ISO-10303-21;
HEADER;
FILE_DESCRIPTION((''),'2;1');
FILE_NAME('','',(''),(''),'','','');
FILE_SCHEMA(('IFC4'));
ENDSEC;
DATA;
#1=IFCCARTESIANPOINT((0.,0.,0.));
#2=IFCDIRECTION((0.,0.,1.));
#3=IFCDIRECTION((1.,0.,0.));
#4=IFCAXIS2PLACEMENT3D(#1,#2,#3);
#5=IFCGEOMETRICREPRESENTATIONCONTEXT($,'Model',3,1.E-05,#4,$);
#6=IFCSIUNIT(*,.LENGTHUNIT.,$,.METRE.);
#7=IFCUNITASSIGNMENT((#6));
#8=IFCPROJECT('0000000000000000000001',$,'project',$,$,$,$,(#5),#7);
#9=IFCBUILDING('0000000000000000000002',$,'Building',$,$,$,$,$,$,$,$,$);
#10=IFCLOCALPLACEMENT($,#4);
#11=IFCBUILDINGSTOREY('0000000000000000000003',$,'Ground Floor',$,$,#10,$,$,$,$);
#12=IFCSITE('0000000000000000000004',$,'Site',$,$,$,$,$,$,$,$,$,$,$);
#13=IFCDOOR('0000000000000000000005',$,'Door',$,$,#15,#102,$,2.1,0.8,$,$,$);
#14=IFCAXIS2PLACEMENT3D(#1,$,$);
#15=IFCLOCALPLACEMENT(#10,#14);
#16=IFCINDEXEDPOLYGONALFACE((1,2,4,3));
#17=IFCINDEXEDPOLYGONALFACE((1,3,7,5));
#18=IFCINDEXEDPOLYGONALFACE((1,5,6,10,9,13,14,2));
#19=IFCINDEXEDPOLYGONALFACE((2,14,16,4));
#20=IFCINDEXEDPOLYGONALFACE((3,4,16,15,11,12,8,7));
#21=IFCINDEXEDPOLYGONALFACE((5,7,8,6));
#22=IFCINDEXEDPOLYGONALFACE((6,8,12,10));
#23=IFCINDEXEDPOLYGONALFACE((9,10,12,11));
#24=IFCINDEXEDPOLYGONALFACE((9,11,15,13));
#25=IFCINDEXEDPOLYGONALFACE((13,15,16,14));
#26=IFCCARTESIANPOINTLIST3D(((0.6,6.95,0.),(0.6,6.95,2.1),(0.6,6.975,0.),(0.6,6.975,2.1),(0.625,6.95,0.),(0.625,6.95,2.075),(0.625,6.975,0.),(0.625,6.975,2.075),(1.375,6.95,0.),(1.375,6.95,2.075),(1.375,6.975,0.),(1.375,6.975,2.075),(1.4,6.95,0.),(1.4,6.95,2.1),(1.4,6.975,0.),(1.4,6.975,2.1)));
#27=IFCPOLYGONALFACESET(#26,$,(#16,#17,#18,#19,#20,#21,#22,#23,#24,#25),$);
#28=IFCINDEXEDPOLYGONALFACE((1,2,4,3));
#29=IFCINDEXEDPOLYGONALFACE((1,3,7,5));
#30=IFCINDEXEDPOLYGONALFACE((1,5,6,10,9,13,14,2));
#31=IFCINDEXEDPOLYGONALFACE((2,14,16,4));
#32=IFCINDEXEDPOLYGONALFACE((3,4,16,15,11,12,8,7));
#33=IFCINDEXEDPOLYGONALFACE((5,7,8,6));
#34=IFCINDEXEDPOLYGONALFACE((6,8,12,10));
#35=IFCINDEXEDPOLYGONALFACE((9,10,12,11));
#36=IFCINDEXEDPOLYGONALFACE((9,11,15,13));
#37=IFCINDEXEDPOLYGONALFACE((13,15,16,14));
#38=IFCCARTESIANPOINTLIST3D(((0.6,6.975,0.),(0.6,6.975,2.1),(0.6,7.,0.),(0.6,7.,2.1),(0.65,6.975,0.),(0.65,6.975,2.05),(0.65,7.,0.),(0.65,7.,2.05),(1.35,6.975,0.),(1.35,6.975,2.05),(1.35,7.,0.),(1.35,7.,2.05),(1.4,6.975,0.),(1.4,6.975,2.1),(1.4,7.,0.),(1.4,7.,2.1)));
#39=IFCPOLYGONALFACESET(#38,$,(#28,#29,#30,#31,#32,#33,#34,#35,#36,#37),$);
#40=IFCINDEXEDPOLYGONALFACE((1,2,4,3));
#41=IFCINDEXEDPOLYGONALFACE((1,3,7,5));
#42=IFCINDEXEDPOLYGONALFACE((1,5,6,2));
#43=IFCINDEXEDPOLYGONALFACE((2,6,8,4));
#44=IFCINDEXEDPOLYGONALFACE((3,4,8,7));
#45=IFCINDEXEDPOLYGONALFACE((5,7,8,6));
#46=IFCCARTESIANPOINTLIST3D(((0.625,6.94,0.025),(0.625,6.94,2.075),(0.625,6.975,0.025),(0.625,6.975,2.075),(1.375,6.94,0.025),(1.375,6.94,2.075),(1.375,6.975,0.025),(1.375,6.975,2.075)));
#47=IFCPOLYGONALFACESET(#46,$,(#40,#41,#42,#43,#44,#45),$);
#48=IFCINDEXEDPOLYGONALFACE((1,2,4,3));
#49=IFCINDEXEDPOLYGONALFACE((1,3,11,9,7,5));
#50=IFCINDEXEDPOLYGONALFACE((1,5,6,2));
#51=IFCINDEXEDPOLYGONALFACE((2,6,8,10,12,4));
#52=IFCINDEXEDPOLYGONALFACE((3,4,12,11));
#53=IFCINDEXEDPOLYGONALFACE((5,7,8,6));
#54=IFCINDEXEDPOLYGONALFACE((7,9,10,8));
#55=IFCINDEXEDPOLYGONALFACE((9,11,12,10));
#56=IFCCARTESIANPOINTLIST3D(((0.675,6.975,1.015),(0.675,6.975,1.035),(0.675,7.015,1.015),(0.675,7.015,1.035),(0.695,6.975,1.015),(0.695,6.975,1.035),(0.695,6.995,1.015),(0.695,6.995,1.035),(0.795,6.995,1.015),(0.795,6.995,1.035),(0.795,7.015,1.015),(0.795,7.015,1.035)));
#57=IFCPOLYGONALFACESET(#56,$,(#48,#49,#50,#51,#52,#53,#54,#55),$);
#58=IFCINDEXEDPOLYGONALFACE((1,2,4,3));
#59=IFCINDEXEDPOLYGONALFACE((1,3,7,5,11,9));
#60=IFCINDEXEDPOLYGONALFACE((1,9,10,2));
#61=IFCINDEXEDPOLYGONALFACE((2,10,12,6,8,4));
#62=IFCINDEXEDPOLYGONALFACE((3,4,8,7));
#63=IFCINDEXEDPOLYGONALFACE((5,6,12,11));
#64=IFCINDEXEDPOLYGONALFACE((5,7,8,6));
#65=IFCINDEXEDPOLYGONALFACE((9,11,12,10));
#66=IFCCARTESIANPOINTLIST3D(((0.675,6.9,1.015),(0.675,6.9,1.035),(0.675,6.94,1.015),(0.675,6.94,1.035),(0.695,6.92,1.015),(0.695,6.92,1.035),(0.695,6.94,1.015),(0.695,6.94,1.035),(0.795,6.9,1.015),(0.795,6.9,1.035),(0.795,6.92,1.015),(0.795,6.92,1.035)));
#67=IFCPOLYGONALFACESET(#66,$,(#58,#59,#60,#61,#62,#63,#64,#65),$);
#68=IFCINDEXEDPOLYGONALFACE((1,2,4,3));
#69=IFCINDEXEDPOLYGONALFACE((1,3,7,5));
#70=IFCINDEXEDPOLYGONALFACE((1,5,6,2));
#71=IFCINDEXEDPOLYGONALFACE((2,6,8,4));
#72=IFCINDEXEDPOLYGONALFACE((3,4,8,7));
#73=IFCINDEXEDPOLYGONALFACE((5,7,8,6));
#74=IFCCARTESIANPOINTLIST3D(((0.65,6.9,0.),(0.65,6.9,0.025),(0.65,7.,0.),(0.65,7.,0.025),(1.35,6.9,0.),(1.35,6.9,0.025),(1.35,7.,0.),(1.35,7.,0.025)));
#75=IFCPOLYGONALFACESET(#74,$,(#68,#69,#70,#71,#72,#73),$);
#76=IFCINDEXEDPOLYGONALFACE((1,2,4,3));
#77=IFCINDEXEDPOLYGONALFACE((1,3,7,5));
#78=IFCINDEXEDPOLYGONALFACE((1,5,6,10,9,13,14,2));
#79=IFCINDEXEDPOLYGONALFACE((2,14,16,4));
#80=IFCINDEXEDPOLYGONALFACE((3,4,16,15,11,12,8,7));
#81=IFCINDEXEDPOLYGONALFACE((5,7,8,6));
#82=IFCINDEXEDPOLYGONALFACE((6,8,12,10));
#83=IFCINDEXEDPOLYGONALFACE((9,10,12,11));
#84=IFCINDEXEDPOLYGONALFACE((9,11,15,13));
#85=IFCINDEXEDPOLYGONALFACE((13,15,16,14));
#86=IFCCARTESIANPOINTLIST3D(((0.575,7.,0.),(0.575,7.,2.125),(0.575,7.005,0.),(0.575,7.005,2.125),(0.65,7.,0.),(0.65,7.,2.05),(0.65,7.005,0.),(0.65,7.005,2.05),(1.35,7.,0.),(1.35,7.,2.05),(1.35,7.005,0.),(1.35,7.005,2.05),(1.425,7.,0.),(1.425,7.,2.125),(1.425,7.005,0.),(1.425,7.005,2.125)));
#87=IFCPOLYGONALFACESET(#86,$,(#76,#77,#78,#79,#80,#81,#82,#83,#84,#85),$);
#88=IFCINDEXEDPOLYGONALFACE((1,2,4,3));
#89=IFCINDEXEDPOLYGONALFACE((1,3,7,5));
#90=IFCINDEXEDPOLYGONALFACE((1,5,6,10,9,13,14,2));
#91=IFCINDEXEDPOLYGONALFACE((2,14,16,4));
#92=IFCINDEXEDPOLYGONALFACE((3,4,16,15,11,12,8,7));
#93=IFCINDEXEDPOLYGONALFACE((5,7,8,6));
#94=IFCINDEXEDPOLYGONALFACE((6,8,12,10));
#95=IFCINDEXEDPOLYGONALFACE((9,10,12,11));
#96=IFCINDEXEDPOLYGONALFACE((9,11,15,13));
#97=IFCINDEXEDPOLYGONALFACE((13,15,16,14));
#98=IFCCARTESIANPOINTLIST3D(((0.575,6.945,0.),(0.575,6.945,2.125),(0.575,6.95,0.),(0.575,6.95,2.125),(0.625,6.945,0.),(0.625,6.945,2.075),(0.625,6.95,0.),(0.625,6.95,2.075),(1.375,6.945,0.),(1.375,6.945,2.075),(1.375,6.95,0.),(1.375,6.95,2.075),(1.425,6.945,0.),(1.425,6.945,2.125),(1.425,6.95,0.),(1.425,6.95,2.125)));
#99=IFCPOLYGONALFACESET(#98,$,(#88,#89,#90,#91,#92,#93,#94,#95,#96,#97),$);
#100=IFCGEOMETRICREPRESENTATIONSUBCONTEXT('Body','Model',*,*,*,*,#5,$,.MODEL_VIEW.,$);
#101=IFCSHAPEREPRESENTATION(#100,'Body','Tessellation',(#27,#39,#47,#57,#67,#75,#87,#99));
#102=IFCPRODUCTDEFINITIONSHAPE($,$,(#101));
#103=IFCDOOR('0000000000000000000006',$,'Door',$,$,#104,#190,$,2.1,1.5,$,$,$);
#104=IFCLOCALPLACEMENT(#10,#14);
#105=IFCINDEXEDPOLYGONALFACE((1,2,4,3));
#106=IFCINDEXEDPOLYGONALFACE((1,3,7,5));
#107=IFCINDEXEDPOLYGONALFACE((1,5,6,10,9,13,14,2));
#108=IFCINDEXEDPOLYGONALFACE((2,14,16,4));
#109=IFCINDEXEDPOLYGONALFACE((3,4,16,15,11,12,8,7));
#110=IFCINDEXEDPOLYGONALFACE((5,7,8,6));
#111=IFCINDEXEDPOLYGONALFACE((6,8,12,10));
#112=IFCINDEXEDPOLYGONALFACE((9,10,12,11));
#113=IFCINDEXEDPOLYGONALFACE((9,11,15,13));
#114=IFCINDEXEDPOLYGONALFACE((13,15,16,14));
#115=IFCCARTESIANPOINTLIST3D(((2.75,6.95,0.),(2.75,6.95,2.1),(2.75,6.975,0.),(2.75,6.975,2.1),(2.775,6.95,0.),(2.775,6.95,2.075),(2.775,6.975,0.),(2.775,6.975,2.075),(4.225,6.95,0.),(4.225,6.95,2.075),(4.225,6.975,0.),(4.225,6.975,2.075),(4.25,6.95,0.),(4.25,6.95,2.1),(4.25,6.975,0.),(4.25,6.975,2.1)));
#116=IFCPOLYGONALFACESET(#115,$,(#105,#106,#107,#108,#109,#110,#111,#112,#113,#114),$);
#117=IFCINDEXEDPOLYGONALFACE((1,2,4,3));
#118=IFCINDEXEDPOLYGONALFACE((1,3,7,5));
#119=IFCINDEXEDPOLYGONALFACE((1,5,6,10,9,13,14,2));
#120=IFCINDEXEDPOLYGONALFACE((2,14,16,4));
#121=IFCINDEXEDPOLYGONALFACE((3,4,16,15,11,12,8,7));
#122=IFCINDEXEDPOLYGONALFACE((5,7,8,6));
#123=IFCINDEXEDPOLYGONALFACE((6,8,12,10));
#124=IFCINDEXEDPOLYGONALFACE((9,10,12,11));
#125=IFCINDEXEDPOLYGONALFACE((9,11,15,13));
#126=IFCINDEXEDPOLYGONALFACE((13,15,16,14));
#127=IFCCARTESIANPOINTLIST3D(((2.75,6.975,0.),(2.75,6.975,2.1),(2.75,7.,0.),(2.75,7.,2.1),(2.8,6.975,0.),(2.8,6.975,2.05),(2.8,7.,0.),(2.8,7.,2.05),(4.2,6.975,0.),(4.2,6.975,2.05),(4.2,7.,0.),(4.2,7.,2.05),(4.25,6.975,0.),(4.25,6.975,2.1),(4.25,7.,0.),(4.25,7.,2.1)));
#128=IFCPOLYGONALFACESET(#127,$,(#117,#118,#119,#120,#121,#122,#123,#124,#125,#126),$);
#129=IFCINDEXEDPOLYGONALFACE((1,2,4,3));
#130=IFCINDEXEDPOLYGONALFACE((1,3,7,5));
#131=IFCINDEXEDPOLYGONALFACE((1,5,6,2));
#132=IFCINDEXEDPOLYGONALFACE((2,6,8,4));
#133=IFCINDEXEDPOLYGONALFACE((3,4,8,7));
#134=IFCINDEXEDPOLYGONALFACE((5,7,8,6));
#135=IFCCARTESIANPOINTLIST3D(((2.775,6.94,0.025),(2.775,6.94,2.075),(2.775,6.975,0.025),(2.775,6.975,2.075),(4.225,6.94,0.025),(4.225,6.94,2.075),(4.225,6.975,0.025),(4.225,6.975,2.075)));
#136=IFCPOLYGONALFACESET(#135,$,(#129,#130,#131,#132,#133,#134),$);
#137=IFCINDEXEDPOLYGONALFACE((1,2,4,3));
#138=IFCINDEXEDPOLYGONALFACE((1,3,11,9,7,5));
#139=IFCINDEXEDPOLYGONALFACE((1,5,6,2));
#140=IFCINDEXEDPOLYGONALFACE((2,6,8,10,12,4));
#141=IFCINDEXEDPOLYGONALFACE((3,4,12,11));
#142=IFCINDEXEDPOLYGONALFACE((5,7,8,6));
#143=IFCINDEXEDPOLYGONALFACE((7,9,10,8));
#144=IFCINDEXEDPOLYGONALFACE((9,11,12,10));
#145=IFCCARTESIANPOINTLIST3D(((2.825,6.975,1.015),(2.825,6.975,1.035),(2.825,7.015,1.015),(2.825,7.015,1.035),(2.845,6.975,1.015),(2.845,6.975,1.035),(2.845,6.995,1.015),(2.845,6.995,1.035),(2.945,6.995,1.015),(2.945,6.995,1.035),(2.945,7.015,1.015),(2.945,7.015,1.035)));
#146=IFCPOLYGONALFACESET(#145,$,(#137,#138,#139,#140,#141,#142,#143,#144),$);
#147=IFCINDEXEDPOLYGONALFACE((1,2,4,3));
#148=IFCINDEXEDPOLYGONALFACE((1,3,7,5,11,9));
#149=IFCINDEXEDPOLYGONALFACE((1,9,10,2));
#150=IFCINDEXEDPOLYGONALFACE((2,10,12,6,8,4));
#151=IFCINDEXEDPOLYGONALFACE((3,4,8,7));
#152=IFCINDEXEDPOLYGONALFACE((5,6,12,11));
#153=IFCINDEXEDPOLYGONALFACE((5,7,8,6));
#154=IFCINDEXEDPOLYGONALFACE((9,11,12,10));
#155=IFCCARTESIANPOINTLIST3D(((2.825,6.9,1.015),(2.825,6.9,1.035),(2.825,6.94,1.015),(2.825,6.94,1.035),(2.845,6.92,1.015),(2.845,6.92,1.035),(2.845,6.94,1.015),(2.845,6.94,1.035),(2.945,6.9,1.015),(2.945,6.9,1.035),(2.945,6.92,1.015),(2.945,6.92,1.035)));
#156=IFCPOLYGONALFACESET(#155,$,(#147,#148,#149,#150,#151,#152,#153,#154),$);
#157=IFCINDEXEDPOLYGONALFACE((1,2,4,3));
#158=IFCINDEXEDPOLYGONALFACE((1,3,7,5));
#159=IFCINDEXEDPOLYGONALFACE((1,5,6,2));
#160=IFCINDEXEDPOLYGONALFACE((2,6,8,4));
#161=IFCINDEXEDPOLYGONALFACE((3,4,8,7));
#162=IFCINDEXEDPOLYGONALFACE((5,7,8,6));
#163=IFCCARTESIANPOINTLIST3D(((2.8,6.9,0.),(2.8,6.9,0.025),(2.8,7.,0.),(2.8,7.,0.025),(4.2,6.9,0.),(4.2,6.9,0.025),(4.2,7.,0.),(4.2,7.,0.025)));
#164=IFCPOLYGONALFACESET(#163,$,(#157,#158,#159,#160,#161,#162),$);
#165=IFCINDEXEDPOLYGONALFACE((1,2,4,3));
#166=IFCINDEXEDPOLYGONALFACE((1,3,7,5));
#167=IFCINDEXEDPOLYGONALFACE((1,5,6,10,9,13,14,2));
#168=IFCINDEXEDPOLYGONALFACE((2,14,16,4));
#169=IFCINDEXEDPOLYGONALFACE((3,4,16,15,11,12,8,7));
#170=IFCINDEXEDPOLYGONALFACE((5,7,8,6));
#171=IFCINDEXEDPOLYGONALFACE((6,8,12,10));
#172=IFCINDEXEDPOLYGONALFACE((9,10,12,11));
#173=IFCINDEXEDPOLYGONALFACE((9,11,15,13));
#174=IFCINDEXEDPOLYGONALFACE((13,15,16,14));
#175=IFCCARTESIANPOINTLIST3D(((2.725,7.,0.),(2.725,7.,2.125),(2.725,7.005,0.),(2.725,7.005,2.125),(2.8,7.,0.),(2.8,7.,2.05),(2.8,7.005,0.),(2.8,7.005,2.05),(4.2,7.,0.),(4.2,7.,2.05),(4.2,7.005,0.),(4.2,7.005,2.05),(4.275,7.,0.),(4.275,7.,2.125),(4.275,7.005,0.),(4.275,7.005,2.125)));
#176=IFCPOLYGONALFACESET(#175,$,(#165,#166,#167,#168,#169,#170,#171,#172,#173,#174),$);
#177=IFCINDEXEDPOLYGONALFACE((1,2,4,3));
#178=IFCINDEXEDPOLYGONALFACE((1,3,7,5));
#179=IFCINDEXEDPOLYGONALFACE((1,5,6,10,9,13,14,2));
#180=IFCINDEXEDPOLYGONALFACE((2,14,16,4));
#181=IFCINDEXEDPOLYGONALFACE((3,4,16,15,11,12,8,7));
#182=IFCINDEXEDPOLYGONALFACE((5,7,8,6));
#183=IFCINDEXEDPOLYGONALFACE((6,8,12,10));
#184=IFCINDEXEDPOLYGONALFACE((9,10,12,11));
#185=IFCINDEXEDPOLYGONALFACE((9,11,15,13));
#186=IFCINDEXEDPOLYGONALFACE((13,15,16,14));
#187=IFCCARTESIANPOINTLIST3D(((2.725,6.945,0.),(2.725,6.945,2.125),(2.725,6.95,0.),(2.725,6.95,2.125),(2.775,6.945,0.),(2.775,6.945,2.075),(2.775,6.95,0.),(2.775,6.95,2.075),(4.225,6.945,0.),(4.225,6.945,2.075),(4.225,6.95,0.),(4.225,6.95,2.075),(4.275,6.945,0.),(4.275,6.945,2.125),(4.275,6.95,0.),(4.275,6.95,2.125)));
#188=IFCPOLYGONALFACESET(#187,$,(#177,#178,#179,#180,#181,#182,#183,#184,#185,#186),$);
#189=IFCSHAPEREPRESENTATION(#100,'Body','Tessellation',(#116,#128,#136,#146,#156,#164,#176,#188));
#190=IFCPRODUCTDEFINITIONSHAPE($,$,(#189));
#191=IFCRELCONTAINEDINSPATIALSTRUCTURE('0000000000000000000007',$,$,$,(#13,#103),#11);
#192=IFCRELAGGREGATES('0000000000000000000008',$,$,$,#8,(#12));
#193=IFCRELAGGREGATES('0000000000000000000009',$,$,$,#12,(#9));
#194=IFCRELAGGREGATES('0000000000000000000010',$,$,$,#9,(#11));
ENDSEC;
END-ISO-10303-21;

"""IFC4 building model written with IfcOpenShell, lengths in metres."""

from ifc_helpers import new_model, si_unit, frame, origin_with_axes, place, context, subcontext, project, spatial, line, indexed_curve, outline, extrude, element, save


model = new_model("IFC4")

# Units and contexts
model_context = context("Model", 3, precision=1e-05, world=origin_with_axes())
body_context = subcontext(model_context, "Body", "Model", "MODEL_VIEW")
ifc_project = project(units=[si_unit("LENGTHUNIT", "METRE")], contexts=[model_context])

# Site, building, storey
site = spatial("IfcSite", under=ifc_project, Name="Site")
building = spatial("IfcBuilding", under=site, Name="Building")
storey_placement = place(None, origin_with_axes())
storey = spatial("IfcBuildingStorey", under=building, at=storey_placement, Name="Ground Floor")

# Doors
door_1_placement = place(storey_placement, frame((1.4, 7.0, 0.0), z_axis=(0.0, 0.0, 1.0), x_axis=(-1.0, 0.0, 0.0)))
element("IfcDoor", 1, at=door_1_placement, inside=storey, Name="Door", OverallHeight=2.1, OverallWidth=0.8, context=body_context, shape_type="SweptSolid", body=[
    extrude(outline(indexed_curve([(0.0, 0.0), (0.0, 2.1), (0.8, 2.1), (0.8, 0.0), (0.775, 0.0), (0.775, 2.075), (0.025, 2.075), (0.025, 0.0)], segments=[line(1, 2, 3, 4, 5, 6, 7, 8, 1)])), frame((0.0, 0.025, 0.0), z_axis=(0.0, -1.0, 0.0), x_axis=(1.0, 0.0, 0.0)), (0.0, 0.0, -1.0), 0.025),
    extrude(outline(indexed_curve([(0.0, 0.0), (0.0, 2.1), (0.8, 2.1), (0.8, 0.0), (0.75, 0.0), (0.75, 2.05), (0.05, 2.05), (0.05, 0.0)], segments=[line(1, 2, 3, 4, 5, 6, 7, 8, 1)])), frame((0.0, 0.0, 0.0), z_axis=(0.0, -1.0, 0.0), x_axis=(1.0, 0.0, 0.0)), (0.0, 0.0, -1.0), 0.025),
    extrude(outline(indexed_curve([(0.0, 0.0), (0.75, 0.0), (0.75, 0.035), (0.0, 0.035)], segments=[line(1, 2, 3, 4, 1)])), frame((0.025, 0.025, 0.025), z_axis=(0.0, 0.0, 1.0), x_axis=(1.0, 0.0, 0.0)), (0.0, 0.0, 1.0), 2.05),
    extrude(outline(indexed_curve([(0.0, 0.0), (0.0, -0.04), (-0.12, -0.04), (-0.12, -0.02), (-0.02, -0.02), (-0.02, 0.0)], segments=[line(1, 2, 3, 4, 5, 6, 1)])), frame((0.725, 0.025, 1.015), z_axis=(0.0, 0.0, 1.0), x_axis=(1.0, 0.0, 0.0)), (0.0, 0.0, 1.0), 0.02),
    extrude(outline(indexed_curve([(0.0, 0.0), (0.0, 0.04), (-0.12, 0.04), (-0.12, 0.02), (-0.02, 0.02), (-0.02, 0.0)], segments=[line(1, 2, 3, 4, 5, 6, 1)])), frame((0.725, 0.06, 1.015), z_axis=(0.0, 0.0, 1.0), x_axis=(1.0, 0.0, 0.0)), (0.0, 0.0, 1.0), 0.02),
    extrude(outline(indexed_curve([(0.0, 0.0), (0.7, 0.0), (0.7, 0.1), (0.0, 0.1)], segments=[line(1, 2, 3, 4, 1)])), frame((0.05, 0.0, 0.0), z_axis=(0.0, 0.0, 1.0), x_axis=(1.0, 0.0, 0.0)), (0.0, 0.0, 1.0), 0.025),
    extrude(outline(indexed_curve([(0.0, 0.0), (0.0, 2.125), (0.85, 2.125), (0.85, 0.0), (0.775, 0.0), (0.775, 2.05), (0.075, 2.05), (0.075, 0.0)], segments=[line(1, 2, 3, 4, 5, 6, 7, 8, 1)])), frame((-0.025, -0.005, 0.0), z_axis=(0.0, -1.0, 0.0), x_axis=(1.0, 0.0, 0.0)), (0.0, 0.0, -1.0), 0.005),
    extrude(outline(indexed_curve([(0.0, 0.0), (0.0, 2.125), (0.85, 2.125), (0.85, 0.0), (0.8, 0.0), (0.8, 2.075), (0.05, 2.075), (0.05, 0.0)], segments=[line(1, 2, 3, 4, 5, 6, 7, 8, 1)])), frame((-0.025, 0.05, 0.0), z_axis=(0.0, -1.0, 0.0), x_axis=(1.0, 0.0, 0.0)), (0.0, 0.0, -1.0), 0.005),
])
door_2_placement = place(storey_placement, frame((4.25, 7.0, 0.0), z_axis=(0.0, 0.0, 1.0), x_axis=(-1.0, 0.0, 0.0)))
element("IfcDoor", 2, at=door_2_placement, inside=storey, Name="Door", OverallHeight=2.1, OverallWidth=1.5, context=body_context, shape_type="SweptSolid", body=[
    extrude(outline(indexed_curve([(0.0, 0.0), (0.0, 2.1), (1.5, 2.1), (1.5, 0.0), (1.475, 0.0), (1.475, 2.075), (0.025, 2.075), (0.025, 0.0)], segments=[line(1, 2, 3, 4, 5, 6, 7, 8, 1)])), frame((0.0, 0.025, 0.0), z_axis=(0.0, -1.0, 0.0), x_axis=(1.0, 0.0, 0.0)), (0.0, 0.0, -1.0), 0.025),
    extrude(outline(indexed_curve([(0.0, 0.0), (0.0, 2.1), (1.5, 2.1), (1.5, 0.0), (1.45, 0.0), (1.45, 2.05), (0.05, 2.05), (0.05, 0.0)], segments=[line(1, 2, 3, 4, 5, 6, 7, 8, 1)])), frame((0.0, 0.0, 0.0), z_axis=(0.0, -1.0, 0.0), x_axis=(1.0, 0.0, 0.0)), (0.0, 0.0, -1.0), 0.025),
    extrude(outline(indexed_curve([(0.0, 0.0), (1.45, 0.0), (1.45, 0.035), (0.0, 0.035)], segments=[line(1, 2, 3, 4, 1)])), frame((0.025, 0.025, 0.025), z_axis=(0.0, 0.0, 1.0), x_axis=(1.0, 0.0, 0.0)), (0.0, 0.0, 1.0), 2.05),
    extrude(outline(indexed_curve([(0.0, 0.0), (0.0, -0.04), (-0.12, -0.04), (-0.12, -0.02), (-0.02, -0.02), (-0.02, 0.0)], segments=[line(1, 2, 3, 4, 5, 6, 1)])), frame((1.425, 0.025, 1.015), z_axis=(0.0, 0.0, 1.0), x_axis=(1.0, 0.0, 0.0)), (0.0, 0.0, 1.0), 0.02),
    extrude(outline(indexed_curve([(0.0, 0.0), (0.0, 0.04), (-0.12, 0.04), (-0.12, 0.02), (-0.02, 0.02), (-0.02, 0.0)], segments=[line(1, 2, 3, 4, 5, 6, 1)])), frame((1.425, 0.06, 1.015), z_axis=(0.0, 0.0, 1.0), x_axis=(1.0, 0.0, 0.0)), (0.0, 0.0, 1.0), 0.02),
    extrude(outline(indexed_curve([(0.0, 0.0), (1.4, 0.0), (1.4, 0.1), (0.0, 0.1)], segments=[line(1, 2, 3, 4, 1)])), frame((0.05, 0.0, 0.0), z_axis=(0.0, 0.0, 1.0), x_axis=(1.0, 0.0, 0.0)), (0.0, 0.0, 1.0), 0.025),
    extrude(outline(indexed_curve([(0.0, 0.0), (0.0, 2.125), (1.55, 2.125), (1.55, 0.0), (1.475, 0.0), (1.475, 2.05), (0.075, 2.05), (0.075, 0.0)], segments=[line(1, 2, 3, 4, 5, 6, 7, 8, 1)])), frame((-0.025, -0.005, 0.0), z_axis=(0.0, -1.0, 0.0), x_axis=(1.0, 0.0, 0.0)), (0.0, 0.0, -1.0), 0.005),
    extrude(outline(indexed_curve([(0.0, 0.0), (0.0, 2.125), (1.55, 2.125), (1.55, 0.0), (1.5, 0.0), (1.5, 2.075), (0.05, 2.075), (0.05, 0.0)], segments=[line(1, 2, 3, 4, 5, 6, 7, 8, 1)])), frame((-0.025, 0.05, 0.0), z_axis=(0.0, -1.0, 0.0), x_axis=(1.0, 0.0, 0.0)), (0.0, 0.0, -1.0), 0.005),
])

save(model, "model.ifc")
